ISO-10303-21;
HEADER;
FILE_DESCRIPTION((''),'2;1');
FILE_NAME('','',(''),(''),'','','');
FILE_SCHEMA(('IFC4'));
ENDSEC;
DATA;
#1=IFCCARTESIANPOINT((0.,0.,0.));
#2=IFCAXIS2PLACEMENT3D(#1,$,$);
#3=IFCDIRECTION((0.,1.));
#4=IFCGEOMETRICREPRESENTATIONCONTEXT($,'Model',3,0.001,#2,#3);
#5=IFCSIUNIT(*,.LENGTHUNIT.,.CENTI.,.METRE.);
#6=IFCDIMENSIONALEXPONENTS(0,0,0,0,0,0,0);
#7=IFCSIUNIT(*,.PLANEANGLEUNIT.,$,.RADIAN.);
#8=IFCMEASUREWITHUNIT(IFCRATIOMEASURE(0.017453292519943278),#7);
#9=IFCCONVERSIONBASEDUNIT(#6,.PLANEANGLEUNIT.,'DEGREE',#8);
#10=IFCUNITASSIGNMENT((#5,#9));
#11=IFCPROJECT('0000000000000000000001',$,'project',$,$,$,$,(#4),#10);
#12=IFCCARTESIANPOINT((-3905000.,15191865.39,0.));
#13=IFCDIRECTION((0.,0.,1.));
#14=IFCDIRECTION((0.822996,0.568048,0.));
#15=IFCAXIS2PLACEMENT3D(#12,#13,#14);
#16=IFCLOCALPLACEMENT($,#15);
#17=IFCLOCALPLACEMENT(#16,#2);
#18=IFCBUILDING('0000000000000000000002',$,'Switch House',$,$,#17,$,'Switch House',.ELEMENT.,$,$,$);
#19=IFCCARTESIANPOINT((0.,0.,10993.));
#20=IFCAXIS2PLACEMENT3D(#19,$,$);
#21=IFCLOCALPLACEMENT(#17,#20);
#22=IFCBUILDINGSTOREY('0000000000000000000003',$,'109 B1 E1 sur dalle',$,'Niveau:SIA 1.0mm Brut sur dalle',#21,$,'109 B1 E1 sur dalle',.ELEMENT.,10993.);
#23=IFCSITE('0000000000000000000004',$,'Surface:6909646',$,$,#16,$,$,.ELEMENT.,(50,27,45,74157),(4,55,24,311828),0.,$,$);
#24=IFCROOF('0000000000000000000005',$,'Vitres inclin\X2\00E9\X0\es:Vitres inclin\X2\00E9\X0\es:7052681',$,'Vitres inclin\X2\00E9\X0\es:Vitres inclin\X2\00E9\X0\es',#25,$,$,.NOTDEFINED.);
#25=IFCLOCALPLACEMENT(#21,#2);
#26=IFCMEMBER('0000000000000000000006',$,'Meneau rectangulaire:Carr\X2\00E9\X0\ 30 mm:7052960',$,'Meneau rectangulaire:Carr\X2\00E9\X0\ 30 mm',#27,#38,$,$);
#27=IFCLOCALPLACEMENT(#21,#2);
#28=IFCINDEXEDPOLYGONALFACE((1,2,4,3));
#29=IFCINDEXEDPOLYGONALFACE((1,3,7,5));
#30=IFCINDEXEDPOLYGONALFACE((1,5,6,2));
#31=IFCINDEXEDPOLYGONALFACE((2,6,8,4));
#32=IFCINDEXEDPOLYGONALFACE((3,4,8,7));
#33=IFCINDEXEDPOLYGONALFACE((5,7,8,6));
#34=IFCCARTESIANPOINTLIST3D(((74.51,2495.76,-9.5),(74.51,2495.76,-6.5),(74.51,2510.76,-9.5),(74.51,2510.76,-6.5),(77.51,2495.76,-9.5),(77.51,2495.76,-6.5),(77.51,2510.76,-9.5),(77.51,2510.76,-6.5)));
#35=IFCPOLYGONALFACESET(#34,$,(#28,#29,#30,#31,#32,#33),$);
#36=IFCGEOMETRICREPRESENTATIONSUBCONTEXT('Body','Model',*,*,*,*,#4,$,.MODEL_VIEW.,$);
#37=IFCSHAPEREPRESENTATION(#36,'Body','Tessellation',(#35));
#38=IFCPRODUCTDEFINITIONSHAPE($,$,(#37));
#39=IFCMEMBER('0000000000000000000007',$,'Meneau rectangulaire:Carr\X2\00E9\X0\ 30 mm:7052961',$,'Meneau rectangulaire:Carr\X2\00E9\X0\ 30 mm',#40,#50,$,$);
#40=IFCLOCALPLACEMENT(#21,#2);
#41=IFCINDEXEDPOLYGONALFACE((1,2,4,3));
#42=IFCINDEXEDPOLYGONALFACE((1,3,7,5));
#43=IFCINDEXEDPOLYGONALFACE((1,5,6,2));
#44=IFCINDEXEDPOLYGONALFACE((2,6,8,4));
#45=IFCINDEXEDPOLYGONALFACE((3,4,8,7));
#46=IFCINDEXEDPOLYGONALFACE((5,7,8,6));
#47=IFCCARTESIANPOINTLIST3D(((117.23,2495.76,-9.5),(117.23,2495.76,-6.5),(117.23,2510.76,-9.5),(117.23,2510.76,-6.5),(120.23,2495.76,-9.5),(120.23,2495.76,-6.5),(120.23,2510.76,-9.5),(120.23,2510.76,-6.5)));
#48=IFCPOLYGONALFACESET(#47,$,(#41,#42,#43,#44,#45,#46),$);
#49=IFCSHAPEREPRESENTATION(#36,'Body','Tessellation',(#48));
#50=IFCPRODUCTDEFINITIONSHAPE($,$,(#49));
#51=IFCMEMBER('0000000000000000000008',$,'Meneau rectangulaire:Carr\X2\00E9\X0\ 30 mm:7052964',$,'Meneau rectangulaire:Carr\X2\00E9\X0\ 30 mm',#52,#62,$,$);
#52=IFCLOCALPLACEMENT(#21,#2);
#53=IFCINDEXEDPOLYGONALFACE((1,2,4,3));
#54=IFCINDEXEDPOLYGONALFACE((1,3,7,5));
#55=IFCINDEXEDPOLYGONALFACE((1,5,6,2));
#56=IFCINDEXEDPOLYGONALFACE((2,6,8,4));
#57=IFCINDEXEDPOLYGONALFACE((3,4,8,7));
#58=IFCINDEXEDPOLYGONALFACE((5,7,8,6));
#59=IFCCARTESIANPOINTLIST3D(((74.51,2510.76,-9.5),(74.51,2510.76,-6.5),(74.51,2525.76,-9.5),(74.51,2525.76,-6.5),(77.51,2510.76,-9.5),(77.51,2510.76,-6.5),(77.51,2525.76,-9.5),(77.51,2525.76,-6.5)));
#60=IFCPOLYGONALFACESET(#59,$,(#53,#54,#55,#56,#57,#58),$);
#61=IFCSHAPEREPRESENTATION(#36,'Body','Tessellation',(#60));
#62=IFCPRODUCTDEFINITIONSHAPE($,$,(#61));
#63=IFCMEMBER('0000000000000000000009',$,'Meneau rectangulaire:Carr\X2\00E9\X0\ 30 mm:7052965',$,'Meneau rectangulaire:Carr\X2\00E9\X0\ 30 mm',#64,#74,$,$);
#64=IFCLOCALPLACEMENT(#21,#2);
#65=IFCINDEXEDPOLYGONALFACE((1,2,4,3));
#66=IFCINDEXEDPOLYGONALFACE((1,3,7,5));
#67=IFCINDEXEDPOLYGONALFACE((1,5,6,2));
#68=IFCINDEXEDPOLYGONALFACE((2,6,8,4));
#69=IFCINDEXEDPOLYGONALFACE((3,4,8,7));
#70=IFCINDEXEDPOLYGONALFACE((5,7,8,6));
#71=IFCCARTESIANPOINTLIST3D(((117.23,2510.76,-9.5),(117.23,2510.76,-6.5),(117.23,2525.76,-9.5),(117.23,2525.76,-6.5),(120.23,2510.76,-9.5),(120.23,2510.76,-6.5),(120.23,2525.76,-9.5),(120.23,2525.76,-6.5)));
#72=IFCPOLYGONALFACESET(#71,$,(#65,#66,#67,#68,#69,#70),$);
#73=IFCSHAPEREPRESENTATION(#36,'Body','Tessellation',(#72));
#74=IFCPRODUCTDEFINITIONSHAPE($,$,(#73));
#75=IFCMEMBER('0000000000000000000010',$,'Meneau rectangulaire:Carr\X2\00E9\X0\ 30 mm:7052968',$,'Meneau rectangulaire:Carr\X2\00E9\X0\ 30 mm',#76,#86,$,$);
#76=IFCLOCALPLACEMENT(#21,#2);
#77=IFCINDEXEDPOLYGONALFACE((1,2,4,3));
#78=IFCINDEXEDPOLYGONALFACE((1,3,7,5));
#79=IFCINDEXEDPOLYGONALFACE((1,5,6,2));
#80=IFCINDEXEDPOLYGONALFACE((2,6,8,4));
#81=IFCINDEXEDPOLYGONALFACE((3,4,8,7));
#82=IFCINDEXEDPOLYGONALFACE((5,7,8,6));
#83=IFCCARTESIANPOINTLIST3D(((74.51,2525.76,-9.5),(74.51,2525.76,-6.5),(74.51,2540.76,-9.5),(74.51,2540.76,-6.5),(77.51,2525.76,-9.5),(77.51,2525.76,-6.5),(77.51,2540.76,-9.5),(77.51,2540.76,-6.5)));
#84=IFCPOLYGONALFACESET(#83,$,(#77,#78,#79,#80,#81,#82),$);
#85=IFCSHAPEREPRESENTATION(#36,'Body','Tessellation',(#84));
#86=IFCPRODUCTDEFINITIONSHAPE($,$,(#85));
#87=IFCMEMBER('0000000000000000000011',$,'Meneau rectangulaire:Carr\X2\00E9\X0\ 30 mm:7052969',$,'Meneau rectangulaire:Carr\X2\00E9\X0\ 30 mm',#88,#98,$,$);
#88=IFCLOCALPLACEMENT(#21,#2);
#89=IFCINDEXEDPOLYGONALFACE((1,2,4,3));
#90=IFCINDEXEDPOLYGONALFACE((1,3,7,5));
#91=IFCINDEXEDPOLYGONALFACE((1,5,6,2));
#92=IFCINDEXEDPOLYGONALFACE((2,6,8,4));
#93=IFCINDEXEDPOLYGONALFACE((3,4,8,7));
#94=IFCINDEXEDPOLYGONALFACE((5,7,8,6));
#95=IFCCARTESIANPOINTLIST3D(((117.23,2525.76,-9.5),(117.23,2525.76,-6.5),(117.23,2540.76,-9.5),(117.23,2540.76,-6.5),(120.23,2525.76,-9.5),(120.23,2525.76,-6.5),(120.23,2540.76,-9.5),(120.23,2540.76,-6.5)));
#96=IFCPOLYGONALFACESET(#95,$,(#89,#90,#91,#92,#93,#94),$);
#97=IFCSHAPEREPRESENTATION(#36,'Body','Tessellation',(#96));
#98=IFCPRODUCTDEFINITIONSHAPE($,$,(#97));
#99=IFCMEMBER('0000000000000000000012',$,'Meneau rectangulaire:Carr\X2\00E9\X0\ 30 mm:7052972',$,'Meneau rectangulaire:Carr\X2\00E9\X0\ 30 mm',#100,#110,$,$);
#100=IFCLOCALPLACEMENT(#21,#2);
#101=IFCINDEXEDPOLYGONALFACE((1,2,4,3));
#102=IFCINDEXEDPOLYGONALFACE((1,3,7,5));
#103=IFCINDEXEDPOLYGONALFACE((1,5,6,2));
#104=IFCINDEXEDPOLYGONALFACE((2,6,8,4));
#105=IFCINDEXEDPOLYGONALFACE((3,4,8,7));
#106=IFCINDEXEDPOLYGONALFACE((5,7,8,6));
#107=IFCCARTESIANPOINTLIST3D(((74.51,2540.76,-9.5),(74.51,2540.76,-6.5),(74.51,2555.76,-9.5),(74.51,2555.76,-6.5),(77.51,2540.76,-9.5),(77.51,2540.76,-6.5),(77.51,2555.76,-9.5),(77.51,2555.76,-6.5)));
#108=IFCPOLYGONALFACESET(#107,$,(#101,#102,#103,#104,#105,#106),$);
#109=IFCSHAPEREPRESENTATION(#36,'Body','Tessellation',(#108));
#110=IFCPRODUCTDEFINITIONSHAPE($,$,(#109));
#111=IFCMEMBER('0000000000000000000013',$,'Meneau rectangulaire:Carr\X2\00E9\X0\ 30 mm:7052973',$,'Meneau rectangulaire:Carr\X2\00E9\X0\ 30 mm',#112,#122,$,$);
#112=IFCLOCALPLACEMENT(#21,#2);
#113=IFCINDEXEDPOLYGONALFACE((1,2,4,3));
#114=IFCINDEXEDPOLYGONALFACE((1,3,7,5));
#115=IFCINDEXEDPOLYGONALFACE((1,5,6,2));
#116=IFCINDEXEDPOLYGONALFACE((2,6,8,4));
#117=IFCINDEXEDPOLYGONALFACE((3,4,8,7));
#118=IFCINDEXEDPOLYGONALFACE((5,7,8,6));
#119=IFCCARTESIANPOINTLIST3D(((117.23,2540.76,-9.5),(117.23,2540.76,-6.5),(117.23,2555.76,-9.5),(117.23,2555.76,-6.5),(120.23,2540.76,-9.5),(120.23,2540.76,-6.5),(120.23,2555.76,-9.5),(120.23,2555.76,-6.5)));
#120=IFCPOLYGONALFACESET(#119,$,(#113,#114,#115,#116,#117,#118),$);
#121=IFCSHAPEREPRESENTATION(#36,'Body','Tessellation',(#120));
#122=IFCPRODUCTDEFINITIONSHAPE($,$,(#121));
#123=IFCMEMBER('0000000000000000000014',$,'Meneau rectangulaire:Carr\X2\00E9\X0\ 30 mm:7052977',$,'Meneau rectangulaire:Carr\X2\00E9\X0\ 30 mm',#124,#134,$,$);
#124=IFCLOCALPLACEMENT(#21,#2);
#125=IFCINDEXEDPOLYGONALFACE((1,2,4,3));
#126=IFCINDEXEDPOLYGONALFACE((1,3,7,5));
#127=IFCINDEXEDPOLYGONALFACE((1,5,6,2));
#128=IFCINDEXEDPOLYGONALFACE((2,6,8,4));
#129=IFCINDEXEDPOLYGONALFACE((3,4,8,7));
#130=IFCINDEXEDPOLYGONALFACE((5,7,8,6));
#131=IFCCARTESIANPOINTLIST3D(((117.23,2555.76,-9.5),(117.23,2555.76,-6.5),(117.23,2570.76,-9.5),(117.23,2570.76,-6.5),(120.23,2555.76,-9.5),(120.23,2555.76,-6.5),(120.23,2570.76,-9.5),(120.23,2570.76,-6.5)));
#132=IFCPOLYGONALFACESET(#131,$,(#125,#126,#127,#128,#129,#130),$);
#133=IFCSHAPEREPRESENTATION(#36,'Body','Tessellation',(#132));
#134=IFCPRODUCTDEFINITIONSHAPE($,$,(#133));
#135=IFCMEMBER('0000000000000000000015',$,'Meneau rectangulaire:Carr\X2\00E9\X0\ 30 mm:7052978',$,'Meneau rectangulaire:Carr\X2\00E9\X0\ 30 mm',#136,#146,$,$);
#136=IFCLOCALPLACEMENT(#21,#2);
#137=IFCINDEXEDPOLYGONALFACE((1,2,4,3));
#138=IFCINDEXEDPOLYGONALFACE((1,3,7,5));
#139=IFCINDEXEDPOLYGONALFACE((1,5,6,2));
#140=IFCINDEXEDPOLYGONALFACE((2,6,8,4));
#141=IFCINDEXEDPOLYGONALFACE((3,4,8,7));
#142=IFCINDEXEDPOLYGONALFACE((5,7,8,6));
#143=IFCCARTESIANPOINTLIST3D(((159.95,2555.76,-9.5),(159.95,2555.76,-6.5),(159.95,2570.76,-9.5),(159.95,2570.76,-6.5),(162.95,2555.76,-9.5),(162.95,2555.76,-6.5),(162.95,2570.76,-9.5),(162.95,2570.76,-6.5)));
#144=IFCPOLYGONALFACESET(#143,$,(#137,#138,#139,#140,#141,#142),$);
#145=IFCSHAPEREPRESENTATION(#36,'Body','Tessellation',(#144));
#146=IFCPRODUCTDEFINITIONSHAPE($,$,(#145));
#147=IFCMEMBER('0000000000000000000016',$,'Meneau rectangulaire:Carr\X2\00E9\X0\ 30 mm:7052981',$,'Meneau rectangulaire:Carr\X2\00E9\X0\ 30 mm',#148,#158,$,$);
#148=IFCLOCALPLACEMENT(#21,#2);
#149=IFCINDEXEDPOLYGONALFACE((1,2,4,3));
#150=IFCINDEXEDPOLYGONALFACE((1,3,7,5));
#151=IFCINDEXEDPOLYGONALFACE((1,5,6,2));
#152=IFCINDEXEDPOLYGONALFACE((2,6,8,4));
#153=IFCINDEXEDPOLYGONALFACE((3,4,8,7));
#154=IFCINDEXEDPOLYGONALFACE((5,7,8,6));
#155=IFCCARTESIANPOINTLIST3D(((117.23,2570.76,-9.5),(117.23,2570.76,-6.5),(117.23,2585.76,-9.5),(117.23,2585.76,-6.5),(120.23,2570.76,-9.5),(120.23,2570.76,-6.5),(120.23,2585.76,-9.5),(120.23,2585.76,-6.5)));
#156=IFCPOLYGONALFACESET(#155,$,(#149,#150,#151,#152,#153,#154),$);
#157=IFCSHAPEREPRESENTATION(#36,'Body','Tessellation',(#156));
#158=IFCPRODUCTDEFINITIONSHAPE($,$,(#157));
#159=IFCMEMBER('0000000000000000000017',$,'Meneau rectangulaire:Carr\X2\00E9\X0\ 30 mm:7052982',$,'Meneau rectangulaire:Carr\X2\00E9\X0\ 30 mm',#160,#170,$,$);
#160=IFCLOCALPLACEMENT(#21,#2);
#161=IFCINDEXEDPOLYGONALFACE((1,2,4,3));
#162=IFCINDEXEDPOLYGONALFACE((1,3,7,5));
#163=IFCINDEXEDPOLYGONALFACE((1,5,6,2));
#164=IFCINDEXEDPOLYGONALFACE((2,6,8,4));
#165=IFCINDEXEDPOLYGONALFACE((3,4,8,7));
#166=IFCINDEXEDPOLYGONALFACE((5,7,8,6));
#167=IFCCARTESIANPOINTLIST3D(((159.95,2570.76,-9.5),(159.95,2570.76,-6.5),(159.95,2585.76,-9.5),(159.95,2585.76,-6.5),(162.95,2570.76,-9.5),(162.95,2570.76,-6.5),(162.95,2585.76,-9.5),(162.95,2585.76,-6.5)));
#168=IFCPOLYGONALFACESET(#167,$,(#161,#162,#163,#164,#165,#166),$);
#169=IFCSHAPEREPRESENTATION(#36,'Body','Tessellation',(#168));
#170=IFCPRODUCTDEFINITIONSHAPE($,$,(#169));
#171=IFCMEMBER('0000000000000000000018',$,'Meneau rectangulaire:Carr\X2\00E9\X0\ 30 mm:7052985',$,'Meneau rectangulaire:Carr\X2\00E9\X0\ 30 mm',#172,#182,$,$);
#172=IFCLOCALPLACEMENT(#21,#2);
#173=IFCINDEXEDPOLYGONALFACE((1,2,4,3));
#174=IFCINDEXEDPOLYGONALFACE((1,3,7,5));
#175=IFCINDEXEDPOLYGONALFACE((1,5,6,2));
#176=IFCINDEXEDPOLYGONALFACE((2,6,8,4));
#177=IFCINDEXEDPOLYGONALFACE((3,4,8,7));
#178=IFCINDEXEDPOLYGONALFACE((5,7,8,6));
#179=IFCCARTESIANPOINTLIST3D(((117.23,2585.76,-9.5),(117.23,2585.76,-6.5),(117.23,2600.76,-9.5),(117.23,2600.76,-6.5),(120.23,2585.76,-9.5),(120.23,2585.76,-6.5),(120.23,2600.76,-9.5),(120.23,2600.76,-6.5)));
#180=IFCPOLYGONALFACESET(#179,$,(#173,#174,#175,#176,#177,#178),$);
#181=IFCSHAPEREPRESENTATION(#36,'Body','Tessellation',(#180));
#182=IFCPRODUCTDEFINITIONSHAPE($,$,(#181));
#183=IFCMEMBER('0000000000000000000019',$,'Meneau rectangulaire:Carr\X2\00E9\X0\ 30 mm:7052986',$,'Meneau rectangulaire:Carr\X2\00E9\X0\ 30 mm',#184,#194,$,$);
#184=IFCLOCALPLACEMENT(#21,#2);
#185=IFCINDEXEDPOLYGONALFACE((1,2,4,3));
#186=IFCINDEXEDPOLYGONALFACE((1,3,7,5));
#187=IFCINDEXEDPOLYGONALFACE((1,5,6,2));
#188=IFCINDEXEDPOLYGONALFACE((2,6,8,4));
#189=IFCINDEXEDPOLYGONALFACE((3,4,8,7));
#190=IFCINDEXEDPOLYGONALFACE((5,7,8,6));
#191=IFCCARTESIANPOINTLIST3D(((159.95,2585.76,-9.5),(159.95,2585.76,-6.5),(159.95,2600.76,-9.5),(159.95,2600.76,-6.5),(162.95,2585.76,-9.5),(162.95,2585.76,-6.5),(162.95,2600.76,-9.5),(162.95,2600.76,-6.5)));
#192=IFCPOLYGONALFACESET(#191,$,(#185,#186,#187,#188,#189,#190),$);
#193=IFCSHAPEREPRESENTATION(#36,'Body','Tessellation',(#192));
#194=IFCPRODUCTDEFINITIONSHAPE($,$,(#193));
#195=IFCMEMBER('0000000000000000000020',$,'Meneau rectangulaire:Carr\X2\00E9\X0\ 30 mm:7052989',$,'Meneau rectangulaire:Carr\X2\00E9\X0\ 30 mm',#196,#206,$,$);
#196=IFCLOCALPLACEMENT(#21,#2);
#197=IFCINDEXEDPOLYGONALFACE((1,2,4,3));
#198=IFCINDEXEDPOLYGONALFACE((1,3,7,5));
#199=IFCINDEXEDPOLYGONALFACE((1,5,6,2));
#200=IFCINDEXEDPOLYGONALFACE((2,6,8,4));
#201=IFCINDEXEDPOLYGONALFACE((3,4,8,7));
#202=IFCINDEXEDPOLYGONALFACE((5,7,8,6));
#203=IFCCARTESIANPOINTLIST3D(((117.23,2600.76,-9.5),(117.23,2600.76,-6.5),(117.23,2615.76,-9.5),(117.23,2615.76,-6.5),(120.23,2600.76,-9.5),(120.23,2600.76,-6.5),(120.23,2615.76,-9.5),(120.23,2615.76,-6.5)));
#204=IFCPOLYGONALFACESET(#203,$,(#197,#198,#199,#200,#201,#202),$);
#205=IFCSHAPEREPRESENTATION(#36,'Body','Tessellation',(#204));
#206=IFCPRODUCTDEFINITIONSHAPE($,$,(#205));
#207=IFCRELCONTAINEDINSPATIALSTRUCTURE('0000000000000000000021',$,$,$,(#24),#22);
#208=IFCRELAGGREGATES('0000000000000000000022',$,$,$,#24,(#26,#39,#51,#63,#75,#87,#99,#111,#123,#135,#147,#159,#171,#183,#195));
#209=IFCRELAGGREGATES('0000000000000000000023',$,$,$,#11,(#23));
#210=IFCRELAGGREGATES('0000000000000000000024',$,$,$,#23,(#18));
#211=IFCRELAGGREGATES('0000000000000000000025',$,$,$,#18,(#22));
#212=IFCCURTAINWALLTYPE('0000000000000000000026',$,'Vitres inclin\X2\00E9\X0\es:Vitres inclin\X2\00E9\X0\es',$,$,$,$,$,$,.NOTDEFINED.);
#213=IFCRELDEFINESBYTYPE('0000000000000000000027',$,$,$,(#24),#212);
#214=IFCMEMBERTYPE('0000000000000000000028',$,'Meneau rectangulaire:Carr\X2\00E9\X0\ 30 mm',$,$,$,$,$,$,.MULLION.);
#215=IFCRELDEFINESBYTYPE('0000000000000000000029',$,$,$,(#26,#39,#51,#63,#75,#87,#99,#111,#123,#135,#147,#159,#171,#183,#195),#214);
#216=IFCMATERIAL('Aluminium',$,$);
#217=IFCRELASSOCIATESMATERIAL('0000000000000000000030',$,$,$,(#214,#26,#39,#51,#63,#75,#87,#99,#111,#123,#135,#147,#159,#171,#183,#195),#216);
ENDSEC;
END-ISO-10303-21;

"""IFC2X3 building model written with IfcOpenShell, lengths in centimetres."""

from ifc_helpers import new_model, entity, si_unit, converted_unit, direction, frame, origin, origin_2d_with_axis, place, context, subcontext, project, spatial, rectangle, extrude, source, transform, mapped, material, type_object, type_shapes, element, aggregate, save


model = new_model("IFC2X3")

# Units and contexts
model_context = context("Model", 3, precision=0.001, world=origin(), true_north=direction((0.0, 1.0)))
body_context = subcontext(model_context, "Body", "Model", "MODEL_VIEW")
ifc_project = project(units=[si_unit("LENGTHUNIT", "METRE", prefix="CENTI"), converted_unit("PLANEANGLEUNIT", "DEGREE", entity("IfcRatioMeasure", 0.017453292519943278), si_unit("PLANEANGLEUNIT", "RADIAN"), dimensions=[0, 0, 0, 0, 0, 0, 0])], contexts=[model_context])

# Site, building, storey
site_placement = place(None, frame((-3905000.0, 15191865.39, 0.0), z_axis=(0.0, 0.0, 1.0), x_axis=(0.822996, 0.568048, 0.0)))
site = spatial("IfcSite", under=ifc_project, at=site_placement, Name="Surface:6909646", CompositionType="ELEMENT", RefLatitude=(50, 27, 45, 74157), RefLongitude=(4, 55, 24, 311828), RefElevation=0.0)
building_placement = place(site_placement, origin())
building = spatial("IfcBuilding", under=site, at=building_placement, Name="Switch House", LongName="Switch House", CompositionType="ELEMENT")
storey_placement = place(building_placement, frame((0.0, 0.0, 10993.0)))
storey = spatial("IfcBuildingStorey", under=building, at=storey_placement, Name="109 B1 E1 sur dalle", ObjectType="Niveau:SIA 1.0mm Brut sur dalle", LongName="109 B1 E1 sur dalle", CompositionType="ELEMENT", Elevation=10993.0)

# Roof, members
curtain_wall_type = type_object("IfcCurtainWallType", Name="Vitres inclinées:Vitres inclinées", PredefinedType="NOTDEFINED")
roof_placement = place(storey_placement, frame((0.0, 0.0, -10993.0)))
roof = element("IfcRoof", 1, at=roof_placement, inside=storey, type_object=curtain_wall_type, Name="Vitres inclinées:Vitres inclinées:7052681", ObjectType="Vitres inclinées:Vitres inclinées", ShapeType="NOTDEFINED")
ifc_material = material(Name="Aluminium")
member_type_1 = type_object("IfcMemberType", Name="Meneau rectangulaire:Carré 30 mm", PredefinedType="MULLION", material=ifc_material)
shared_shape_1 = source(origin(), body_context, "Body", "SweptSolid", [
    extrude(rectangle(XDim=3.0, YDim=3.0, at=origin_2d_with_axis()), frame((0.0, 0.0, -15.0), z_axis=(0.0, 0.0, 1.0), x_axis=(0.0, -1.0, 0.0)), (0.0, 0.0, 1.0), 15.0),
])
type_shapes(member_type_1, [shared_shape_1])
member_1_placement = place(roof_placement, frame((76.01, 2510.76, 10985.0), z_axis=(0.0, 1.0, 0.0), x_axis=(1.0, 0.0, 0.0)))
member_1 = element("IfcMember", 2, at=member_1_placement, type_object=member_type_1, material=ifc_material, Name="Meneau rectangulaire:Carré 30 mm:7052960", ObjectType="Meneau rectangulaire:Carré 30 mm", context=body_context, shape_type="MappedRepresentation", body=[
    mapped(shared_shape_1, transform((0.0, 0.0, 0.0), scale=1.0)),
])
member_2_placement = place(roof_placement, frame((118.73, 2510.76, 10985.0), z_axis=(0.0, 1.0, 0.0), x_axis=(1.0, 0.0, 0.0)))
member_2 = element("IfcMember", 3, at=member_2_placement, type_object=member_type_1, material=ifc_material, Name="Meneau rectangulaire:Carré 30 mm:7052961", ObjectType="Meneau rectangulaire:Carré 30 mm", context=body_context, shape_type="MappedRepresentation", body=[
    mapped(shared_shape_1, transform((0.0, 0.0, 0.0), scale=1.0)),
])
member_3_placement = place(roof_placement, frame((76.01, 2525.76, 10985.0), z_axis=(0.0, 1.0, 0.0), x_axis=(1.0, 0.0, 0.0)))
member_3 = element("IfcMember", 4, at=member_3_placement, type_object=member_type_1, material=ifc_material, Name="Meneau rectangulaire:Carré 30 mm:7052964", ObjectType="Meneau rectangulaire:Carré 30 mm", context=body_context, shape_type="MappedRepresentation", body=[
    mapped(shared_shape_1, transform((0.0, 0.0, 0.0), scale=1.0)),
])
member_4_placement = place(roof_placement, frame((118.73, 2525.76, 10985.0), z_axis=(0.0, 1.0, 0.0), x_axis=(1.0, 0.0, 0.0)))
member_4 = element("IfcMember", 5, at=member_4_placement, type_object=member_type_1, material=ifc_material, Name="Meneau rectangulaire:Carré 30 mm:7052965", ObjectType="Meneau rectangulaire:Carré 30 mm", context=body_context, shape_type="MappedRepresentation", body=[
    mapped(shared_shape_1, transform((0.0, 0.0, 0.0), scale=1.0)),
])
member_5_placement = place(roof_placement, frame((76.01, 2540.76, 10985.0), z_axis=(0.0, 1.0, 0.0), x_axis=(1.0, 0.0, 0.0)))
member_5 = element("IfcMember", 6, at=member_5_placement, type_object=member_type_1, material=ifc_material, Name="Meneau rectangulaire:Carré 30 mm:7052968", ObjectType="Meneau rectangulaire:Carré 30 mm", context=body_context, shape_type="MappedRepresentation", body=[
    mapped(shared_shape_1, transform((0.0, 0.0, 0.0), scale=1.0)),
])
member_6_placement = place(roof_placement, frame((118.73, 2540.76, 10985.0), z_axis=(0.0, 1.0, 0.0), x_axis=(1.0, 0.0, 0.0)))
member_6 = element("IfcMember", 7, at=member_6_placement, type_object=member_type_1, material=ifc_material, Name="Meneau rectangulaire:Carré 30 mm:7052969", ObjectType="Meneau rectangulaire:Carré 30 mm", context=body_context, shape_type="MappedRepresentation", body=[
    mapped(shared_shape_1, transform((0.0, 0.0, 0.0), scale=1.0)),
])
member_7_placement = place(roof_placement, frame((76.01, 2555.76, 10985.0), z_axis=(0.0, 1.0, 0.0), x_axis=(1.0, 0.0, 0.0)))
member_7 = element("IfcMember", 8, at=member_7_placement, type_object=member_type_1, material=ifc_material, Name="Meneau rectangulaire:Carré 30 mm:7052972", ObjectType="Meneau rectangulaire:Carré 30 mm", context=body_context, shape_type="MappedRepresentation", body=[
    mapped(shared_shape_1, transform((0.0, 0.0, 0.0), scale=1.0)),
])
member_8_placement = place(roof_placement, frame((118.73, 2555.76, 10985.0), z_axis=(0.0, 1.0, 0.0), x_axis=(1.0, 0.0, 0.0)))
member_8 = element("IfcMember", 9, at=member_8_placement, type_object=member_type_1, material=ifc_material, Name="Meneau rectangulaire:Carré 30 mm:7052973", ObjectType="Meneau rectangulaire:Carré 30 mm", context=body_context, shape_type="MappedRepresentation", body=[
    mapped(shared_shape_1, transform((0.0, 0.0, 0.0), scale=1.0)),
])
member_9_placement = place(roof_placement, frame((118.73, 2570.76, 10985.0), z_axis=(0.0, 1.0, 0.0), x_axis=(1.0, 0.0, 0.0)))
member_9 = element("IfcMember", 10, at=member_9_placement, type_object=member_type_1, material=ifc_material, Name="Meneau rectangulaire:Carré 30 mm:7052977", ObjectType="Meneau rectangulaire:Carré 30 mm", context=body_context, shape_type="MappedRepresentation", body=[
    mapped(shared_shape_1, transform((0.0, 0.0, 0.0), scale=1.0)),
])
member_10_placement = place(roof_placement, frame((161.45, 2570.76, 10985.0), z_axis=(0.0, 1.0, 0.0), x_axis=(1.0, 0.0, 0.0)))
member_10 = element("IfcMember", 11, at=member_10_placement, type_object=member_type_1, material=ifc_material, Name="Meneau rectangulaire:Carré 30 mm:7052978", ObjectType="Meneau rectangulaire:Carré 30 mm", context=body_context, shape_type="MappedRepresentation", body=[
    mapped(shared_shape_1, transform((0.0, 0.0, 0.0), scale=1.0)),
])
member_11_placement = place(roof_placement, frame((118.73, 2585.76, 10985.0), z_axis=(0.0, 1.0, 0.0), x_axis=(1.0, 0.0, 0.0)))
member_11 = element("IfcMember", 12, at=member_11_placement, type_object=member_type_1, material=ifc_material, Name="Meneau rectangulaire:Carré 30 mm:7052981", ObjectType="Meneau rectangulaire:Carré 30 mm", context=body_context, shape_type="MappedRepresentation", body=[
    mapped(shared_shape_1, transform((0.0, 0.0, 0.0), scale=1.0)),
])
member_12_placement = place(roof_placement, frame((161.45, 2585.76, 10985.0), z_axis=(0.0, 1.0, 0.0), x_axis=(1.0, 0.0, 0.0)))
member_12 = element("IfcMember", 13, at=member_12_placement, type_object=member_type_1, material=ifc_material, Name="Meneau rectangulaire:Carré 30 mm:7052982", ObjectType="Meneau rectangulaire:Carré 30 mm", context=body_context, shape_type="MappedRepresentation", body=[
    mapped(shared_shape_1, transform((0.0, 0.0, 0.0), scale=1.0)),
])
member_13_placement = place(roof_placement, frame((118.73, 2600.76, 10985.0), z_axis=(0.0, 1.0, 0.0), x_axis=(1.0, 0.0, 0.0)))
member_13 = element("IfcMember", 14, at=member_13_placement, type_object=member_type_1, material=ifc_material, Name="Meneau rectangulaire:Carré 30 mm:7052985", ObjectType="Meneau rectangulaire:Carré 30 mm", context=body_context, shape_type="MappedRepresentation", body=[
    mapped(shared_shape_1, transform((0.0, 0.0, 0.0), scale=1.0)),
])
member_14_placement = place(roof_placement, frame((161.45, 2600.76, 10985.0), z_axis=(0.0, 1.0, 0.0), x_axis=(1.0, 0.0, 0.0)))
member_14 = element("IfcMember", 15, at=member_14_placement, type_object=member_type_1, material=ifc_material, Name="Meneau rectangulaire:Carré 30 mm:7052986", ObjectType="Meneau rectangulaire:Carré 30 mm", context=body_context, shape_type="MappedRepresentation", body=[
    mapped(shared_shape_1, transform((0.0, 0.0, 0.0), scale=1.0)),
])
member_15_placement = place(roof_placement, frame((118.73, 2615.76, 10985.0), z_axis=(0.0, 1.0, 0.0), x_axis=(1.0, 0.0, 0.0)))
member_15 = element("IfcMember", 16, at=member_15_placement, type_object=member_type_1, material=ifc_material, Name="Meneau rectangulaire:Carré 30 mm:7052989", ObjectType="Meneau rectangulaire:Carré 30 mm", context=body_context, shape_type="MappedRepresentation", body=[
    mapped(shared_shape_1, transform((0.0, 0.0, 0.0), scale=1.0)),
])
aggregate(roof, [member_1, member_2, member_3, member_4, member_5, member_6, member_7, member_8, member_9, member_10, member_11, member_12, member_13, member_14, member_15])

save(model, "model.ifc")
